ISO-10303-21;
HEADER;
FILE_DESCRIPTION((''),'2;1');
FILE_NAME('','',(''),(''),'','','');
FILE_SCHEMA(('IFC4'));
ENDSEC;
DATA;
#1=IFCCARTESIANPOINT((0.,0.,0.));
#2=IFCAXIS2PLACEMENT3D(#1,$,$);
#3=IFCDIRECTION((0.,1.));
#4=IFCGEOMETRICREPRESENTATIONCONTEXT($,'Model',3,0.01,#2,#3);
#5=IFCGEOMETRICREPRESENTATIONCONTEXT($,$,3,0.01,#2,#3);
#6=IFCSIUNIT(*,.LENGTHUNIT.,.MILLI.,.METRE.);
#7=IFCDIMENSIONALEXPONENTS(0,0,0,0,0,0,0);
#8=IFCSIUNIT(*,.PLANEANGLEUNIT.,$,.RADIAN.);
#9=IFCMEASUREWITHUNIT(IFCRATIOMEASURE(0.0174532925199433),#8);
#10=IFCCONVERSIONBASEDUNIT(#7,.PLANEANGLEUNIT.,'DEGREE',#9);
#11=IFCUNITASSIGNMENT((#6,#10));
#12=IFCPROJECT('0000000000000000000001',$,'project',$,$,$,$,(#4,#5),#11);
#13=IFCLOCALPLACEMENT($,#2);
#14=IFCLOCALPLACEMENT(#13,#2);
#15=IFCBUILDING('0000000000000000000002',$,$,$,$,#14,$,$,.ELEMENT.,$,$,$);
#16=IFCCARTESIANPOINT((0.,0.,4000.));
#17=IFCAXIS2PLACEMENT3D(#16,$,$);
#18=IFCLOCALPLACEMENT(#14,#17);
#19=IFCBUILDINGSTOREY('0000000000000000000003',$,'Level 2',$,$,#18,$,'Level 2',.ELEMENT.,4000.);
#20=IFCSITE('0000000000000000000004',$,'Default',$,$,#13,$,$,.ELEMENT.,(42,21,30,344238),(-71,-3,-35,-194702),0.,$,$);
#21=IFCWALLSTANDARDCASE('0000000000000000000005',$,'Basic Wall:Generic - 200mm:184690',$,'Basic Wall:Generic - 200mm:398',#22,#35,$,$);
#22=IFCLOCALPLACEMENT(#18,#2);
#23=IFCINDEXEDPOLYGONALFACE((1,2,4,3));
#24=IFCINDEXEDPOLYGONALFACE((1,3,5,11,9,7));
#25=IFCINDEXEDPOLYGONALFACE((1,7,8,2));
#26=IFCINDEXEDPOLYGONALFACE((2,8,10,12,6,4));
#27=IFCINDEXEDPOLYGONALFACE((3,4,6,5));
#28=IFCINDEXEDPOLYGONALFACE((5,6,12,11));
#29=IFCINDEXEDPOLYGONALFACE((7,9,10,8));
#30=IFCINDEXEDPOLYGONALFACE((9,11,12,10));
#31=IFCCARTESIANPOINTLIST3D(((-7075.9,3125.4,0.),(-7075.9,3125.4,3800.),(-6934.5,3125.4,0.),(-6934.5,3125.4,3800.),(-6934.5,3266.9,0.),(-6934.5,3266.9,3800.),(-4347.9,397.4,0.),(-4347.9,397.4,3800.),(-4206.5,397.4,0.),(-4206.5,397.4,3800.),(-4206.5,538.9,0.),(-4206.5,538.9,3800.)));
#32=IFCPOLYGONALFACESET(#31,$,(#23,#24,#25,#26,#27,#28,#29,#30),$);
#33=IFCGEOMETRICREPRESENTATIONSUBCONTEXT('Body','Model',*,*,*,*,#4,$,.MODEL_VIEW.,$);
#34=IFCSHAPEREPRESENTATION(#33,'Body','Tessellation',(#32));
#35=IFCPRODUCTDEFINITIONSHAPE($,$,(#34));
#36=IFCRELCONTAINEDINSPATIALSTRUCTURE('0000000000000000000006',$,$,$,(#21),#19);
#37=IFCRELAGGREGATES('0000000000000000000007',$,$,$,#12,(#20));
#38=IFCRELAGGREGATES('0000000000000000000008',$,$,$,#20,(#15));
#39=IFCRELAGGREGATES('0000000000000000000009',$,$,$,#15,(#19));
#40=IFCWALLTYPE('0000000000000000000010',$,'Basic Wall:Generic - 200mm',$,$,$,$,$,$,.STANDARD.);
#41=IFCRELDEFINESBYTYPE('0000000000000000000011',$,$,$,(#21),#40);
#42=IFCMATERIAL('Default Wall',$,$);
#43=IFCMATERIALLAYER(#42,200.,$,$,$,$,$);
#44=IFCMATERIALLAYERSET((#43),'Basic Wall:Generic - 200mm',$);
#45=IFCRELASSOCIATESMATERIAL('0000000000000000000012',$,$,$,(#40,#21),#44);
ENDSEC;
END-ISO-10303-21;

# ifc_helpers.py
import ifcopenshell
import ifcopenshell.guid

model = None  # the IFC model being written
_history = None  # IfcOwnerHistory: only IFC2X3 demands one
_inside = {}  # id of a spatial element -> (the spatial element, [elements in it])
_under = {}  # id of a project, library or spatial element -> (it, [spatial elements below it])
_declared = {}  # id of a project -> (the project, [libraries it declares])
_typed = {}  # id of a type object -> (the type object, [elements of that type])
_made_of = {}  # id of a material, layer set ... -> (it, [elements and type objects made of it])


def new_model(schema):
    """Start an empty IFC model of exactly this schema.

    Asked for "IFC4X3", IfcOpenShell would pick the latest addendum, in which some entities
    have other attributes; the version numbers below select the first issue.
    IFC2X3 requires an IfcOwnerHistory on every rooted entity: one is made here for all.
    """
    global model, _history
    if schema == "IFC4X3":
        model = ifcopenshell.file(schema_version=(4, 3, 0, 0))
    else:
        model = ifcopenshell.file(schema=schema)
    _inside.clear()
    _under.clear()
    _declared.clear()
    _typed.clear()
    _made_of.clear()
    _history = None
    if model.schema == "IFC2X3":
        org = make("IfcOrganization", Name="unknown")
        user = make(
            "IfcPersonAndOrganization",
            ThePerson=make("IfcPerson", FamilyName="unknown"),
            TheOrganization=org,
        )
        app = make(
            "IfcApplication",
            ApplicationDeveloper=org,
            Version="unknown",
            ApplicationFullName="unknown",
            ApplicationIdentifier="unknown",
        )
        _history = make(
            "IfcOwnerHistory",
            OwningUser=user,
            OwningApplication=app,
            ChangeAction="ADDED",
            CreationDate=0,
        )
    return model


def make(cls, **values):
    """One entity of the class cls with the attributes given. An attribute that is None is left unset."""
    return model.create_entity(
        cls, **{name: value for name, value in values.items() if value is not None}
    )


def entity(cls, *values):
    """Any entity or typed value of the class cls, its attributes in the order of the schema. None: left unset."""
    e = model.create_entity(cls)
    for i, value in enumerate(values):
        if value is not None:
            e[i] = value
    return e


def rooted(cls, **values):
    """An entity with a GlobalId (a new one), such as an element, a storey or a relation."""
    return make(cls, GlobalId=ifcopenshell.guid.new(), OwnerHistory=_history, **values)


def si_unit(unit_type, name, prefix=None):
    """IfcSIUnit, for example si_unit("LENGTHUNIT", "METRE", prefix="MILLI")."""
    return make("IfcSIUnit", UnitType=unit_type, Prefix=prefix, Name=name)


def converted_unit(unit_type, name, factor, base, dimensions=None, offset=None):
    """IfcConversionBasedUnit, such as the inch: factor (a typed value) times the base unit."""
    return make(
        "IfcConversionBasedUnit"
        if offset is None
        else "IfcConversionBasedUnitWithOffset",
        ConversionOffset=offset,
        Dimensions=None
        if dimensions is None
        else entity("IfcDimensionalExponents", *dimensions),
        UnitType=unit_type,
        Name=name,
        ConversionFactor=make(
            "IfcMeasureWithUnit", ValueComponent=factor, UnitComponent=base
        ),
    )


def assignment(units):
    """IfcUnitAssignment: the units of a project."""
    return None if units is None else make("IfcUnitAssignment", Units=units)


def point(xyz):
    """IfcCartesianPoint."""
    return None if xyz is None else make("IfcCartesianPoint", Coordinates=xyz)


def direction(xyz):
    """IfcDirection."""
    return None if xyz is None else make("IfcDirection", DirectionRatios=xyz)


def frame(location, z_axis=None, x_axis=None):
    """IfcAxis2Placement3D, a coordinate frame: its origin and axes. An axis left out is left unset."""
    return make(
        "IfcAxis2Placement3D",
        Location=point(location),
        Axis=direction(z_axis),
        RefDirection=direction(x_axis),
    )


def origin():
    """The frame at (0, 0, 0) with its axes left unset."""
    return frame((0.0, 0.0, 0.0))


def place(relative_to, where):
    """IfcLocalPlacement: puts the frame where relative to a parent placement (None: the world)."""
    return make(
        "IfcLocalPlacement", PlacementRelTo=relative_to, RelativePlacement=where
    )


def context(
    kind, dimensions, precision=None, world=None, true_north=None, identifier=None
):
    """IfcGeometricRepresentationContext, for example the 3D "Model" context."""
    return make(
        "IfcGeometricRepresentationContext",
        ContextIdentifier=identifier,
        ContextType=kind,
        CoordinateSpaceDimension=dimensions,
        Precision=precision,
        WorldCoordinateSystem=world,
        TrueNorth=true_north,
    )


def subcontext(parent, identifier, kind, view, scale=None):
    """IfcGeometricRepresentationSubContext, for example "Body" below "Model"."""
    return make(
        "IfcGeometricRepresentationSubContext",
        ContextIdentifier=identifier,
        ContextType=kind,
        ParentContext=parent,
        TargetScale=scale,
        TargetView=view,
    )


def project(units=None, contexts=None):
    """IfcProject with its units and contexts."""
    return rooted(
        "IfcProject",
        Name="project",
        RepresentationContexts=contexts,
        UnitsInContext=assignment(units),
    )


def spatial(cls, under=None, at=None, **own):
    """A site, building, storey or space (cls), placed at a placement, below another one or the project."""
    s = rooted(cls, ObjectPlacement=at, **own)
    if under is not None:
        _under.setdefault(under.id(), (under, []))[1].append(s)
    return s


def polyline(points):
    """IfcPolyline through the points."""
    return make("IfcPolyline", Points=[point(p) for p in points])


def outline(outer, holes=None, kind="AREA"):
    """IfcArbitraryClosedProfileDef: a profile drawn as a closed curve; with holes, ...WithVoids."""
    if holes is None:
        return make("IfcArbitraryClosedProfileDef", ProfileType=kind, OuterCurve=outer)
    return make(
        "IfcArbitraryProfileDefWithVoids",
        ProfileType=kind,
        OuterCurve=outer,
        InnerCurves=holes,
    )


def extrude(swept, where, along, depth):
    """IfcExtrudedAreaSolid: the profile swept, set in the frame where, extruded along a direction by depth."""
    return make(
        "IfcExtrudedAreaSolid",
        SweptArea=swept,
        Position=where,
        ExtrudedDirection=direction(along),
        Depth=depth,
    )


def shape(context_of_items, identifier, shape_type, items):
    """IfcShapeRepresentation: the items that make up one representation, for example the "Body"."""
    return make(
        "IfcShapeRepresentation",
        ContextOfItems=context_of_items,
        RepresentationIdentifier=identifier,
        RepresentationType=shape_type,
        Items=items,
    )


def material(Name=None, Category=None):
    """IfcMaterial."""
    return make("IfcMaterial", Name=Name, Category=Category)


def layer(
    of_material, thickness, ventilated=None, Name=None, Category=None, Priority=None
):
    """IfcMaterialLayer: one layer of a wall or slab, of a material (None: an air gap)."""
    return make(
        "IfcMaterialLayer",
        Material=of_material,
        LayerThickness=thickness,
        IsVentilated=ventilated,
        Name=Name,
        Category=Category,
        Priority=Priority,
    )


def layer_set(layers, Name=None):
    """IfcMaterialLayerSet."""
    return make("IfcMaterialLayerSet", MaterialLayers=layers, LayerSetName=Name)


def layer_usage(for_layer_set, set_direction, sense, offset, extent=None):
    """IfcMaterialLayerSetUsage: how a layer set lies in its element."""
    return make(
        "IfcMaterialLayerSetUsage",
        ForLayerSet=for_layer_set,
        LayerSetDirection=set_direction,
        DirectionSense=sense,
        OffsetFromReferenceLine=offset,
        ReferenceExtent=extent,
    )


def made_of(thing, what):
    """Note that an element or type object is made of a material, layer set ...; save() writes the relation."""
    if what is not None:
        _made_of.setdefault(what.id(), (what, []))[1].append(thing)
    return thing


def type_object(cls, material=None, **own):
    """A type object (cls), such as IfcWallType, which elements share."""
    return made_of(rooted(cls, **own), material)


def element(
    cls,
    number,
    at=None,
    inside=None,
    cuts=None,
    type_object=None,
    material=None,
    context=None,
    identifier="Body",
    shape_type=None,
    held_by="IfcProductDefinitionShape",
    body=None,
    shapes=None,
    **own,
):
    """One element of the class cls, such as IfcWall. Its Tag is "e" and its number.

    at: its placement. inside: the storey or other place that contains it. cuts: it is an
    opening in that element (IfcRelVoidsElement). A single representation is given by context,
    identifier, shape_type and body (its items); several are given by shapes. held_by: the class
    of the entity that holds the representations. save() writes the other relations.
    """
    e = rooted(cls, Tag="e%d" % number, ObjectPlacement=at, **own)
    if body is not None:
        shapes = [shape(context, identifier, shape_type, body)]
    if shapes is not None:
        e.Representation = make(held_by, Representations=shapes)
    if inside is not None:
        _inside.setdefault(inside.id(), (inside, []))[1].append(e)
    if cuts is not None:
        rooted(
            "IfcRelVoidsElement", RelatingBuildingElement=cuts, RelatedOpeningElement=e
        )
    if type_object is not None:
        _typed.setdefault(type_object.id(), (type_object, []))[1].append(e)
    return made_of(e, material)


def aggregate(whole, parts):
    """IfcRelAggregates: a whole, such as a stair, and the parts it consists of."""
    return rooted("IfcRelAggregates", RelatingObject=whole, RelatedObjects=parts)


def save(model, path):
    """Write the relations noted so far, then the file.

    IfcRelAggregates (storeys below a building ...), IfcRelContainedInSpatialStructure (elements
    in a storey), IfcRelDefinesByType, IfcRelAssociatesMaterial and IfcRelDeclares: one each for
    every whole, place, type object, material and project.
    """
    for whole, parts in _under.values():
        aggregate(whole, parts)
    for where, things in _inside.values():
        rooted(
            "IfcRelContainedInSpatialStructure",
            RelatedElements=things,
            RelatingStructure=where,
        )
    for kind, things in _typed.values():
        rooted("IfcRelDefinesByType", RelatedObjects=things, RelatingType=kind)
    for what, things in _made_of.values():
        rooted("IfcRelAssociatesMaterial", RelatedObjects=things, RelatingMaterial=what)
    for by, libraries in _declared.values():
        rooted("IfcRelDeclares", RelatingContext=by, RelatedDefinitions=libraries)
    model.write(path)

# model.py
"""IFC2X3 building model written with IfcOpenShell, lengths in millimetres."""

from ifc_helpers import new_model, entity, si_unit, converted_unit, direction, frame, origin, place, context, subcontext, project, spatial, polyline, outline, extrude, material, layer, layer_set, layer_usage, type_object, element, save


model = new_model("IFC2X3")

# Units and contexts
model_context = context("Model", 3, precision=0.01, world=origin(), true_north=direction((0.0, 1.0)))
context_of_model = context(None, 3, precision=0.01, world=origin(), true_north=direction((0.0, 1.0)))
body_context = subcontext(model_context, "Body", "Model", "MODEL_VIEW")
ifc_project = project(units=[si_unit("LENGTHUNIT", "METRE", prefix="MILLI"), converted_unit("PLANEANGLEUNIT", "DEGREE", entity("IfcRatioMeasure", 0.0174532925199433), si_unit("PLANEANGLEUNIT", "RADIAN"), dimensions=[0, 0, 0, 0, 0, 0, 0])], contexts=[model_context, context_of_model])

# Site, building, storey
site_placement = place(None, origin())
site = spatial("IfcSite", under=ifc_project, at=site_placement, Name="Default", CompositionType="ELEMENT", RefLatitude=(42, 21, 30, 344238), RefLongitude=(-71, -3, -35, -194702), RefElevation=0.0)
building_placement = place(site_placement, origin())
building = spatial("IfcBuilding", under=site, at=building_placement, CompositionType="ELEMENT")
storey_placement = place(building_placement, frame((0.0, 0.0, 4000.0)))
storey = spatial("IfcBuildingStorey", under=building, at=storey_placement, Name="Level 2", LongName="Level 2", CompositionType="ELEMENT", Elevation=4000.0)

# Wall
ifc_material_1 = material(Name="Default Wall")
ifc_layer_1 = layer(ifc_material_1, 200.0)
ifc_layer_set_1 = layer_set([ifc_layer_1], Name="Basic Wall:Generic - 200mm")
wall_type = type_object("IfcWallType", Name="Basic Wall:Generic - 200mm", PredefinedType="STANDARD", material=ifc_layer_set_1)
ifc_layer_usage_1 = layer_usage(ifc_layer_set_1, "AXIS2", "NEGATIVE", 100.0)
wall_1_placement = place(storey_placement, frame((-7005.2, 3196.2, 0.0), z_axis=(0.0, 0.0, 1.0), x_axis=(0.707107, -0.707107, 0.0)))
element("IfcWallStandardCase", 1, at=wall_1_placement, inside=storey, type_object=wall_type, material=ifc_layer_usage_1, Name="Basic Wall:Generic - 200mm:184690", ObjectType="Basic Wall:Generic - 200mm:398", context=body_context, shape_type="SweptSolid", body=[
    extrude(outline(polyline([(3858.0, -100.0), (3958.0, 0.0), (3858.0, 100.0), (0.0, 100.0), (100.0, 0.0), (0.0, -100.0), (3858.0, -100.0)])), origin(), (0.0, 0.0, 1.0), 3800.0),
])

save(model, "model.ifc")
